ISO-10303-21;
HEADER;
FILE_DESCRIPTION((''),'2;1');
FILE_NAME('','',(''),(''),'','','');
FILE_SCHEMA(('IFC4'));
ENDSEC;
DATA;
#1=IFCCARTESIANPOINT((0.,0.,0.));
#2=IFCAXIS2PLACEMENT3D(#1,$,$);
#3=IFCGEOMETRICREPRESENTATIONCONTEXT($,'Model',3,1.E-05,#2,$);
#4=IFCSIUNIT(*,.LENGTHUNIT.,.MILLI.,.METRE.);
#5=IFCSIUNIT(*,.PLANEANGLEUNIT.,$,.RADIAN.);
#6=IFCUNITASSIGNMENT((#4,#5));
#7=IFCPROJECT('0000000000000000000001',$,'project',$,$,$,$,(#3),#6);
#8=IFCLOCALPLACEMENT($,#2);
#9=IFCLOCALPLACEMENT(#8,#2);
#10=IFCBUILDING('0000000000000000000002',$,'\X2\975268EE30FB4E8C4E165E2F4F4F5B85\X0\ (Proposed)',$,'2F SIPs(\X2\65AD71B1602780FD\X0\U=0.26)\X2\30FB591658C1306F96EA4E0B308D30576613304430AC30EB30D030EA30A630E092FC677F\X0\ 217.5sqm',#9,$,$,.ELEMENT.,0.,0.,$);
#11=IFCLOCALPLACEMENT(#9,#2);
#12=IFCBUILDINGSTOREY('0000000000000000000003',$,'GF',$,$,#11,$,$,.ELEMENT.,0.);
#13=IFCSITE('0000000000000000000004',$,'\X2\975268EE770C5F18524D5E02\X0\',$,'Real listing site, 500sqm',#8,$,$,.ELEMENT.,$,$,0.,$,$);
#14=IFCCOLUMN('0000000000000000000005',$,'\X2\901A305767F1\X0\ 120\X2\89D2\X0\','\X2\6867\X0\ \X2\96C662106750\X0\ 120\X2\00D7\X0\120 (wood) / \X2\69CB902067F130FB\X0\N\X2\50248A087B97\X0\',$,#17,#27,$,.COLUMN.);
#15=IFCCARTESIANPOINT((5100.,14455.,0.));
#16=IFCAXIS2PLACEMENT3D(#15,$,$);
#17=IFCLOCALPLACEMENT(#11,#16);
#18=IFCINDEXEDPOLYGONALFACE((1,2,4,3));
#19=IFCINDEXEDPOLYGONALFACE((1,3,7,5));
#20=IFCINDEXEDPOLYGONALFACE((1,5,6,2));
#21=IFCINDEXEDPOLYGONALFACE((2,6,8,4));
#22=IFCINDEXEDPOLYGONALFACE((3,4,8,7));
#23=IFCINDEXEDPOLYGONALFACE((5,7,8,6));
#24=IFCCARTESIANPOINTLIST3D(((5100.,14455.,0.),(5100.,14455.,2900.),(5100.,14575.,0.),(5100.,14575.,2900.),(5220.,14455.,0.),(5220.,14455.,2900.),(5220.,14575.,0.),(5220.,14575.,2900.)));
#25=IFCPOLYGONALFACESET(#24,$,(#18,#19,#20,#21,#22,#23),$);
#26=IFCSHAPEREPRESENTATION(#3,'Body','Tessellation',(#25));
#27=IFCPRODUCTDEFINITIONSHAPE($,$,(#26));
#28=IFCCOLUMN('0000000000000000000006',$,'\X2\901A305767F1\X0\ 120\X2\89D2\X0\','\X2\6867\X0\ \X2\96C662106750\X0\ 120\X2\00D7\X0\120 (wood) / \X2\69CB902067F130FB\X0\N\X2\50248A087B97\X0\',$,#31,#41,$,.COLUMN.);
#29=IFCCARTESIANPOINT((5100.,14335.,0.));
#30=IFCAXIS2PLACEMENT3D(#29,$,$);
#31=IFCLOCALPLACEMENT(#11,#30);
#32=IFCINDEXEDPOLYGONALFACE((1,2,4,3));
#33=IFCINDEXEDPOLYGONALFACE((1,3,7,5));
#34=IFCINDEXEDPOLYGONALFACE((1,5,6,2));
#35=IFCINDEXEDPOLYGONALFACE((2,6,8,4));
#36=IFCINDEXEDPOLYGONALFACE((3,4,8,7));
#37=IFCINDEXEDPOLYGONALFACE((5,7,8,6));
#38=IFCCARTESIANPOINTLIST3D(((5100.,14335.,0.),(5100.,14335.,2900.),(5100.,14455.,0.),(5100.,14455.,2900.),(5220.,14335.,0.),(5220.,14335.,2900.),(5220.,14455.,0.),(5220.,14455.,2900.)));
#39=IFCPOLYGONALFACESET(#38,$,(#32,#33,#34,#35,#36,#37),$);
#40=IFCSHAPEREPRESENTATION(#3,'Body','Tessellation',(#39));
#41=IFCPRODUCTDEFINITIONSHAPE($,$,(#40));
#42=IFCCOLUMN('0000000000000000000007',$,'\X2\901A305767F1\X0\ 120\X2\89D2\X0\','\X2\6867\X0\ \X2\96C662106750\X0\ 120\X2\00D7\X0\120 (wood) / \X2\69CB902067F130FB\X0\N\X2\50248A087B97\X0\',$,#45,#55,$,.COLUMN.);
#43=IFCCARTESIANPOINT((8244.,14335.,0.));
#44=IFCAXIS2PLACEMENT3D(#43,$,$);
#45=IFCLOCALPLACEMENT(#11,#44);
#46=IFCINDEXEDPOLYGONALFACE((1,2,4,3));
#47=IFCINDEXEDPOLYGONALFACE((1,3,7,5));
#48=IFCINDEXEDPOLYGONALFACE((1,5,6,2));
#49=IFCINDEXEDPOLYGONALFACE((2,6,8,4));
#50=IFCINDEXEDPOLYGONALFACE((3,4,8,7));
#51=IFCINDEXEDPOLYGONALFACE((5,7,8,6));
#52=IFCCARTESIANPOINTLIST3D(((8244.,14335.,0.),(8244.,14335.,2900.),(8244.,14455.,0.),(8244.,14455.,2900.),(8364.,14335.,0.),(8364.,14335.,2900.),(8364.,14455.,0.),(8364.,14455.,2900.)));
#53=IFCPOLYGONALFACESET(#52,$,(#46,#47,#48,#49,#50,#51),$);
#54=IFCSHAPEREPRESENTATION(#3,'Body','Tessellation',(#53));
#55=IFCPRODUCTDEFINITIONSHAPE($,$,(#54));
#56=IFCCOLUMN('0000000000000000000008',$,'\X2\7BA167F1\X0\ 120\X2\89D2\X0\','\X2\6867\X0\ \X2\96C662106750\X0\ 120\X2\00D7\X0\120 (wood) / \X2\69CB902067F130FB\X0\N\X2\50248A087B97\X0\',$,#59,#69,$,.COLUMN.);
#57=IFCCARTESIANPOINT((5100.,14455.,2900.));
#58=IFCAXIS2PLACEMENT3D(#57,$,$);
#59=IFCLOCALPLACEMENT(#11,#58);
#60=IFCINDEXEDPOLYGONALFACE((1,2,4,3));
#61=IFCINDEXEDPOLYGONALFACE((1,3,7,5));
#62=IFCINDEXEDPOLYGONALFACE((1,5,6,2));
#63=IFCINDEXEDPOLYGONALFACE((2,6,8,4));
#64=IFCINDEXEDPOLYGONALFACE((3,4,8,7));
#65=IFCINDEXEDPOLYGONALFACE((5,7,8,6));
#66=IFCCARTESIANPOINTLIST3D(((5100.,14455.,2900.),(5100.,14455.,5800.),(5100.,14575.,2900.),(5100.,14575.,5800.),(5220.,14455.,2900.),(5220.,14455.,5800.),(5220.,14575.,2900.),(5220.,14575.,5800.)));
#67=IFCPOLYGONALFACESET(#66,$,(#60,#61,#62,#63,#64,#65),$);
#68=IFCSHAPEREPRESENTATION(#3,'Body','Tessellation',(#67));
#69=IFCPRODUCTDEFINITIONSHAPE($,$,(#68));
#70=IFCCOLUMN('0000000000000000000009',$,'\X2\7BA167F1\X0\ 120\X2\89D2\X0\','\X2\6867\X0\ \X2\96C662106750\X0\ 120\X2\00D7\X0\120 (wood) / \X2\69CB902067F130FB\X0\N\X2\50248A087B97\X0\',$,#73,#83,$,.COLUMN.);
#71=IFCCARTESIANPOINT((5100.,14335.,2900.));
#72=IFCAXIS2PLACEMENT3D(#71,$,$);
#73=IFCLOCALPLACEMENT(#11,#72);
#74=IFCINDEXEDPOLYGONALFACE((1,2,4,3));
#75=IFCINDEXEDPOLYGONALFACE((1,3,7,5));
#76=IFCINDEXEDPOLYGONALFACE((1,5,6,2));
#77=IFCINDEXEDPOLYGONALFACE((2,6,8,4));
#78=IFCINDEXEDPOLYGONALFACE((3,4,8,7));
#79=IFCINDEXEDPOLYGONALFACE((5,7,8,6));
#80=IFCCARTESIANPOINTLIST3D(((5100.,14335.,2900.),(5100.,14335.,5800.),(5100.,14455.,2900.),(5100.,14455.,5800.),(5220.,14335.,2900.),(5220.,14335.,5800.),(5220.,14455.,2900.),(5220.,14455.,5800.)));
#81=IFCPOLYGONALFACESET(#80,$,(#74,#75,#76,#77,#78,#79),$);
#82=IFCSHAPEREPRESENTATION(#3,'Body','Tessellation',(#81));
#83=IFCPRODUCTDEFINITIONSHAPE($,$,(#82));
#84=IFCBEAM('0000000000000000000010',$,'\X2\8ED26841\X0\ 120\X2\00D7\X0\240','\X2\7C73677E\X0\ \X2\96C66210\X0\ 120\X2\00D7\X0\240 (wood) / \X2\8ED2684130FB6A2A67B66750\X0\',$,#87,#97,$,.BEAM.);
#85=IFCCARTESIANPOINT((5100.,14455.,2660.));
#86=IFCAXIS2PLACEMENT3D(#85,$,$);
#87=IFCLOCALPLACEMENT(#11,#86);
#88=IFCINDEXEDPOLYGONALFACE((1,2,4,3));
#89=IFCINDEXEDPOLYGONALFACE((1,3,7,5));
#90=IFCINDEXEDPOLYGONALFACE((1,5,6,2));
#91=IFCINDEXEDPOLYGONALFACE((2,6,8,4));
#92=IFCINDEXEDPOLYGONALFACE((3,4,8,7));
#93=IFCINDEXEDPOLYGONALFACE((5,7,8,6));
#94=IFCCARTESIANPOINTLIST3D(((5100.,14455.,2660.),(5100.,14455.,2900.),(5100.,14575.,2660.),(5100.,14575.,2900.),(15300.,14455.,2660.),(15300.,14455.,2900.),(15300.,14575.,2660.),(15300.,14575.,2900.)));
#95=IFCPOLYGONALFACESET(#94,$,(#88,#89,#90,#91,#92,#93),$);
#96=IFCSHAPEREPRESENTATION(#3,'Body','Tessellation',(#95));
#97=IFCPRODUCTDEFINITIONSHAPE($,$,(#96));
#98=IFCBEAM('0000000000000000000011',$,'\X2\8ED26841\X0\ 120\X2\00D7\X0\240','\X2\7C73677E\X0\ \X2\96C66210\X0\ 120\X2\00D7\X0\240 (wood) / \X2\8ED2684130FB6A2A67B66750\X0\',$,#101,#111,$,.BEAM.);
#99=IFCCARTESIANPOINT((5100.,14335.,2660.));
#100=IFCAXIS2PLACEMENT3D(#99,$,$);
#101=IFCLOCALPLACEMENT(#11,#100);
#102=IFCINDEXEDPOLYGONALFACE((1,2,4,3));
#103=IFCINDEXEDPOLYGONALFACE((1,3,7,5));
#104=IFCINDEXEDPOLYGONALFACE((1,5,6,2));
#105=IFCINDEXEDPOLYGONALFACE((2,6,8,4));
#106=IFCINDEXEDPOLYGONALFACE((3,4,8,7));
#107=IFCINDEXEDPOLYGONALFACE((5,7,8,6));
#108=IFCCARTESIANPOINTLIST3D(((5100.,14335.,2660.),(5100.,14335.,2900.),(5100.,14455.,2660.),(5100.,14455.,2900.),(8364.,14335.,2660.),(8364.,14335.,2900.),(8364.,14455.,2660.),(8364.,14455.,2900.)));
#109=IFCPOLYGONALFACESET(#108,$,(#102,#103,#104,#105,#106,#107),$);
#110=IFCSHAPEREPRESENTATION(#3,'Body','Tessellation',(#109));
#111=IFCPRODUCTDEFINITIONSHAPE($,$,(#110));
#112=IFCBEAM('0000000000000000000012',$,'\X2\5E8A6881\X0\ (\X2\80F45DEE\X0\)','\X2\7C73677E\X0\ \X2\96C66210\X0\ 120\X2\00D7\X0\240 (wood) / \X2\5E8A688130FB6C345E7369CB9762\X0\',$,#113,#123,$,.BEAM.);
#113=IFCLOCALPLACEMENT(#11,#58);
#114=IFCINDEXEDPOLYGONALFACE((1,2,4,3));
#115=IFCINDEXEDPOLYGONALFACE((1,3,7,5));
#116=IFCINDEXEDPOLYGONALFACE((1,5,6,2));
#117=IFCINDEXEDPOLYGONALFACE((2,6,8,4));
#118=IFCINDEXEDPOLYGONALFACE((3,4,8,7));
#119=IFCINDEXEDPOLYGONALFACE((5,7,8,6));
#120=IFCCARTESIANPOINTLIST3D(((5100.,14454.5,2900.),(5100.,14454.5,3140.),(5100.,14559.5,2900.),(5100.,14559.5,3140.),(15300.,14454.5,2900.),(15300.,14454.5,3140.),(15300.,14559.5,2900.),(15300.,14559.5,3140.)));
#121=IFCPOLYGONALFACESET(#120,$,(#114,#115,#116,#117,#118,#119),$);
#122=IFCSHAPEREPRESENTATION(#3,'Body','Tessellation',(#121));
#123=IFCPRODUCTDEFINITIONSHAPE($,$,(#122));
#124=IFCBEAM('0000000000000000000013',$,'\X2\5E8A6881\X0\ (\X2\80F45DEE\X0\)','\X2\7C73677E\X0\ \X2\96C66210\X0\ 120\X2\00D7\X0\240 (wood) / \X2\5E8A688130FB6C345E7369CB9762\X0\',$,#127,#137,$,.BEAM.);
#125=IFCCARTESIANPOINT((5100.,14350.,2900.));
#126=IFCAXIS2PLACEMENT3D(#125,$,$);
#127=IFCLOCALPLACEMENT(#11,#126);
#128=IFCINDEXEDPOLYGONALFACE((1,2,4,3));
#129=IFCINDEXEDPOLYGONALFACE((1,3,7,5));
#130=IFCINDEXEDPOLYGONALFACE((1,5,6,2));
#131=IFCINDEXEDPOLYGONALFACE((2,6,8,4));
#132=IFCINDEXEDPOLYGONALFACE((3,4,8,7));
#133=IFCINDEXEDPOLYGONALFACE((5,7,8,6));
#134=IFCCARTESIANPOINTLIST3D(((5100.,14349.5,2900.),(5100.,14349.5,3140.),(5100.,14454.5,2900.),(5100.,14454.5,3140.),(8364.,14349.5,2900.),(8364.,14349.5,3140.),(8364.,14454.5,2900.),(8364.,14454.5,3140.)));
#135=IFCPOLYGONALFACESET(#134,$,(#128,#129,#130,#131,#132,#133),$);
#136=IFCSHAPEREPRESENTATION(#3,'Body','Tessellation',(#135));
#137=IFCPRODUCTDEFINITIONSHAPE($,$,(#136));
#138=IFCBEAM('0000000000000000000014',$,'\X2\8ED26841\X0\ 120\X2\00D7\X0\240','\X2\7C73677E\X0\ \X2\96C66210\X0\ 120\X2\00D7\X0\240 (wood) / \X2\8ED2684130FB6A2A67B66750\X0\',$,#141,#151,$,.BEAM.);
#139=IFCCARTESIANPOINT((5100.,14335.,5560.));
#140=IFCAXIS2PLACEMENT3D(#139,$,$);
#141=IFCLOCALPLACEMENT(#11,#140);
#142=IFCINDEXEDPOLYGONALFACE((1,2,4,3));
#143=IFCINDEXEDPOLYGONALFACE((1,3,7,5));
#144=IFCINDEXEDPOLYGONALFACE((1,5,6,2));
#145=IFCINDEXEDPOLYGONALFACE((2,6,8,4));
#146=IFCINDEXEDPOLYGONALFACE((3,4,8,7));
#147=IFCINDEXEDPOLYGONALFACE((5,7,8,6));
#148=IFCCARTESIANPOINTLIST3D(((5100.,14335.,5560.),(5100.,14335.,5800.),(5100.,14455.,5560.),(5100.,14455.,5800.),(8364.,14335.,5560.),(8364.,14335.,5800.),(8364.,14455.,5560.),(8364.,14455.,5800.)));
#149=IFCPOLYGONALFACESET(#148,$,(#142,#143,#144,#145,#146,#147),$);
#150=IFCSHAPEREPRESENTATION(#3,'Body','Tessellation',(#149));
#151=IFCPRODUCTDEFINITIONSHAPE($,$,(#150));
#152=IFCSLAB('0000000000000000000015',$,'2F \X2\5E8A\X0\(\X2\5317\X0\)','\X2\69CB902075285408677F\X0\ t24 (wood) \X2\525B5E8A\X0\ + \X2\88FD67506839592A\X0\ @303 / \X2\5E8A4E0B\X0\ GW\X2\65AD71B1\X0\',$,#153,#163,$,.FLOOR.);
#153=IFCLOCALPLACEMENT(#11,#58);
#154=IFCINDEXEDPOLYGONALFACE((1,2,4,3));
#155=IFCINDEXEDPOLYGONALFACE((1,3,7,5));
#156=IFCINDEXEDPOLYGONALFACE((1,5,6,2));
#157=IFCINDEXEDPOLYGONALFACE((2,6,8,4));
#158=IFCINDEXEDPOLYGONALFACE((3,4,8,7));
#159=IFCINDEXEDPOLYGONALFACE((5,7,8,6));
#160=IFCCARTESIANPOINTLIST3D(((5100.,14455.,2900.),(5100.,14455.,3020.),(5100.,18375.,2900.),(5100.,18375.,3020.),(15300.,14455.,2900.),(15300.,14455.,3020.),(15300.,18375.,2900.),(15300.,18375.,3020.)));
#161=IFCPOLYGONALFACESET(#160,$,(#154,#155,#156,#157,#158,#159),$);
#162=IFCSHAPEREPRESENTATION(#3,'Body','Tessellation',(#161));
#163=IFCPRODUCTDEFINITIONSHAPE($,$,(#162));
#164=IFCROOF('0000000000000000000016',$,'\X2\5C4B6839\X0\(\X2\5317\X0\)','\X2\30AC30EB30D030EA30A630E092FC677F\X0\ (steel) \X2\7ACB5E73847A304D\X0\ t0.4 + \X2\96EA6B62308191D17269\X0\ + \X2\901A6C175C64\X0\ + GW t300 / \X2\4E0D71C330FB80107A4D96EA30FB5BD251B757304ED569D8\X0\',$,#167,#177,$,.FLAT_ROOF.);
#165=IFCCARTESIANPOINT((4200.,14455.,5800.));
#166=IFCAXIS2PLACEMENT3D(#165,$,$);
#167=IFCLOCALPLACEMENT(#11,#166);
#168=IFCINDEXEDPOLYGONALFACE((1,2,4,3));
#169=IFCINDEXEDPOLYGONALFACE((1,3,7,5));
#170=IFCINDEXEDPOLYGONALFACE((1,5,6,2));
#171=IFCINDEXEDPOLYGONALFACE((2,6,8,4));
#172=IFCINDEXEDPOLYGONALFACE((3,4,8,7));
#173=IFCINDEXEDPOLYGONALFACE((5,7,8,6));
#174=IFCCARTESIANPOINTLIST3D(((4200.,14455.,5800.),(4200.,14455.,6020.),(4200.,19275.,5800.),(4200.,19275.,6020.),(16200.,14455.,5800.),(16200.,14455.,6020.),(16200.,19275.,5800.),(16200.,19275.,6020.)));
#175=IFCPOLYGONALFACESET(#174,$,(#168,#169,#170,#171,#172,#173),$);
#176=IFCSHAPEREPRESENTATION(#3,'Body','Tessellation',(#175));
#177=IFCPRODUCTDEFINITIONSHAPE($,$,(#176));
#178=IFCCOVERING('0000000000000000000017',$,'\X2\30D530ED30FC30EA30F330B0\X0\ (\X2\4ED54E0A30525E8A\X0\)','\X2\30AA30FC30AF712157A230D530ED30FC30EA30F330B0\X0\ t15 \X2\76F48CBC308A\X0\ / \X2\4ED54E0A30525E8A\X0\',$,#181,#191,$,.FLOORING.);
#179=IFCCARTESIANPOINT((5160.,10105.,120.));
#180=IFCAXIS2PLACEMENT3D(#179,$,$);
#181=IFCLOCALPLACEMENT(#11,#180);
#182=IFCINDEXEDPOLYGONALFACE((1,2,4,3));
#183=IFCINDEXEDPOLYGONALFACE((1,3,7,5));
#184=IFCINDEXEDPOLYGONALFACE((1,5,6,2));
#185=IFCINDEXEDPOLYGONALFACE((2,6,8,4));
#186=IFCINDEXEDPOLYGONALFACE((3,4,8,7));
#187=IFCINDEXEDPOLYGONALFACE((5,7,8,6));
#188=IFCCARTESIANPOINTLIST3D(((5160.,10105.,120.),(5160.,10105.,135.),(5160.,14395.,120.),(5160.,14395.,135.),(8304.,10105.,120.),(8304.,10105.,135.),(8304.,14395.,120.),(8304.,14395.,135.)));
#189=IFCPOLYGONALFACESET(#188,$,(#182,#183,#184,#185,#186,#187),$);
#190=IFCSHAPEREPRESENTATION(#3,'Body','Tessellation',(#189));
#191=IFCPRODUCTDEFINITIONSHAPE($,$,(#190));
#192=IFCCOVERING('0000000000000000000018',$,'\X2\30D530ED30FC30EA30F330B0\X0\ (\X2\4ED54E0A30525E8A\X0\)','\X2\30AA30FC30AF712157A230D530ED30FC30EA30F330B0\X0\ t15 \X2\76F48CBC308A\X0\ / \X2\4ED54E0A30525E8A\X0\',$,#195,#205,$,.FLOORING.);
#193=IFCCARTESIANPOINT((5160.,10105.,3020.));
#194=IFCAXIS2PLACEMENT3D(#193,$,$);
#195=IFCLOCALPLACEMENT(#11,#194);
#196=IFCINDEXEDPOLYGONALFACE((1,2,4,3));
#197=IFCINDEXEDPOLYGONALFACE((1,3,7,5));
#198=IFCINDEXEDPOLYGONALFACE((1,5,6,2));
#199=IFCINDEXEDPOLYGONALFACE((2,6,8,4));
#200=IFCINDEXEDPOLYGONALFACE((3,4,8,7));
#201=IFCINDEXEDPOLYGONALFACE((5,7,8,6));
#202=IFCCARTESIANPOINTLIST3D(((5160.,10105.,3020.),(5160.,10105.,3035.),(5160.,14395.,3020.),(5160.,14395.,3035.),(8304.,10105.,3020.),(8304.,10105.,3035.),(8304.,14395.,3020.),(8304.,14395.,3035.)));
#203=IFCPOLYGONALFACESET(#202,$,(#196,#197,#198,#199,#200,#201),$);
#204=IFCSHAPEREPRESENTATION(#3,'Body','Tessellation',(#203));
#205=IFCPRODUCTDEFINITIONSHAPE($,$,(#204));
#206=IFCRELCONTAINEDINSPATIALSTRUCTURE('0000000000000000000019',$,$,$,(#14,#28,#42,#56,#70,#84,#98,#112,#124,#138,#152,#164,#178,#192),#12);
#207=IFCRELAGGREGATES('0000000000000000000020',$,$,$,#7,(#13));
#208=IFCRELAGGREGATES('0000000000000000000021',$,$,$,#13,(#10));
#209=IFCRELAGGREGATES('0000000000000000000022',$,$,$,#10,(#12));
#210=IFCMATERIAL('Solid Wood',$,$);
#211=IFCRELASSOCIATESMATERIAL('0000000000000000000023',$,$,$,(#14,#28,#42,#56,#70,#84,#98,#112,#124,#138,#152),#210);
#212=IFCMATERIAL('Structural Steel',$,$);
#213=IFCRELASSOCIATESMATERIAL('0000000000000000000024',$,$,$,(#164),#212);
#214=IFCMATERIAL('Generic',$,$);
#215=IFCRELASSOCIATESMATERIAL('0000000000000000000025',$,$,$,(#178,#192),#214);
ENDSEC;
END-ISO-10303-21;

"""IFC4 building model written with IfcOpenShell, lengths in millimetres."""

from ifc_helpers import new_model, si_unit, frame, frame_2d, origin, place, context, project, spatial, rectangle, extrude, material, element, save


model = new_model("IFC4")

# Units and contexts
model_context = context("Model", 3, precision=1e-05, world=origin())
ifc_project = project(units=[si_unit("LENGTHUNIT", "METRE", prefix="MILLI"), si_unit("PLANEANGLEUNIT", "RADIAN")], contexts=[model_context])

# Site, building, storey
site_placement = place(None, origin())
site = spatial("IfcSite", under=ifc_project, at=site_placement, Name="青森県弘前市", ObjectType="Real listing site, 500sqm", CompositionType="ELEMENT", RefElevation=0.0)
building_placement = place(site_placement, origin())
building = spatial("IfcBuilding", under=site, at=building_placement, Name="青森・二世帯住宅 (Proposed)", ObjectType="2F SIPs(断熱性能U=0.26)・外壁は雪下ろし易いガルバリウム鋼板 217.5sqm", CompositionType="ELEMENT", ElevationOfRefHeight=0.0, ElevationOfTerrain=0.0)
storey_placement = place(building_placement, origin())
storey = spatial("IfcBuildingStorey", under=building, at=storey_placement, Name="GF", CompositionType="ELEMENT", Elevation=0.0)

# Columns
ifc_material_1 = material(Name="Solid Wood")
column_1_placement = place(storey_placement, frame((5100.0, 14455.0, 0.0)))
element("IfcColumn", 1, at=column_1_placement, inside=storey, material=ifc_material_1, Name="通し柱 120角", Description="桧 集成材 120×120 (wood) / 構造柱・N値計算", PredefinedType="COLUMN", context=model_context, shape_type="SweptSolid", body=[
    extrude(rectangle(XDim=120.0, YDim=120.0, at=frame_2d((60.0, 60.0))), frame((5100.0, 14455.0, 0.0)), (0.0, 0.0, 1.0), 2900.0),
])
column_2_placement = place(storey_placement, frame((5100.0, 14335.0, 0.0)))
element("IfcColumn", 2, at=column_2_placement, inside=storey, material=ifc_material_1, Name="通し柱 120角", Description="桧 集成材 120×120 (wood) / 構造柱・N値計算", PredefinedType="COLUMN", context=model_context, shape_type="SweptSolid", body=[
    extrude(rectangle(XDim=120.0, YDim=120.0, at=frame_2d((60.0, 60.0))), frame((5100.0, 14335.0, 0.0)), (0.0, 0.0, 1.0), 2900.0),
])
column_3_placement = place(storey_placement, frame((8244.0, 14335.0, 0.0)))
element("IfcColumn", 3, at=column_3_placement, inside=storey, material=ifc_material_1, Name="通し柱 120角", Description="桧 集成材 120×120 (wood) / 構造柱・N値計算", PredefinedType="COLUMN", context=model_context, shape_type="SweptSolid", body=[
    extrude(rectangle(XDim=120.0, YDim=120.0, at=frame_2d((60.0, 60.0))), frame((8244.0, 14335.0, 0.0)), (0.0, 0.0, 1.0), 2900.0),
])
column_4_placement = place(storey_placement, frame((5100.0, 14455.0, 2900.0)))
element("IfcColumn", 4, at=column_4_placement, inside=storey, material=ifc_material_1, Name="管柱 120角", Description="桧 集成材 120×120 (wood) / 構造柱・N値計算", PredefinedType="COLUMN", context=model_context, shape_type="SweptSolid", body=[
    extrude(rectangle(XDim=120.0, YDim=120.0, at=frame_2d((60.0, 60.0))), frame((5100.0, 14455.0, 2900.0)), (0.0, 0.0, 1.0), 2900.0),
])
column_5_placement = place(storey_placement, frame((5100.0, 14335.0, 2900.0)))
element("IfcColumn", 5, at=column_5_placement, inside=storey, material=ifc_material_1, Name="管柱 120角", Description="桧 集成材 120×120 (wood) / 構造柱・N値計算", PredefinedType="COLUMN", context=model_context, shape_type="SweptSolid", body=[
    extrude(rectangle(XDim=120.0, YDim=120.0, at=frame_2d((60.0, 60.0))), frame((5100.0, 14335.0, 2900.0)), (0.0, 0.0, 1.0), 2900.0),
])

# Beams
beam_1_placement = place(storey_placement, frame((5100.0, 14455.0, 2660.0)))
element("IfcBeam", 6, at=beam_1_placement, inside=storey, material=ifc_material_1, Name="軒桁 120×240", Description="米松 集成 120×240 (wood) / 軒桁・横架材", PredefinedType="BEAM", context=model_context, shape_type="SweptSolid", body=[
    extrude(rectangle(XDim=10200.0, YDim=120.0, at=frame_2d((5100.0, 60.0))), frame((5100.0, 14455.0, 2660.0)), (0.0, 0.0, 1.0), 240.0),
])
beam_2_placement = place(storey_placement, frame((5100.0, 14335.0, 2660.0)))
element("IfcBeam", 7, at=beam_2_placement, inside=storey, material=ifc_material_1, Name="軒桁 120×240", Description="米松 集成 120×240 (wood) / 軒桁・横架材", PredefinedType="BEAM", context=model_context, shape_type="SweptSolid", body=[
    extrude(rectangle(XDim=3264.0, YDim=120.0, at=frame_2d((1632.0, 60.0))), frame((5100.0, 14335.0, 2660.0)), (0.0, 0.0, 1.0), 240.0),
])
beam_3_placement = place(storey_placement, frame((5100.0, 14455.0, 2900.0)))
element("IfcBeam", 8, at=beam_3_placement, inside=storey, material=ifc_material_1, Name="床梁 (胴差)", Description="米松 集成 120×240 (wood) / 床梁・水平構面", PredefinedType="BEAM", context=model_context, shape_type="SweptSolid", body=[
    extrude(rectangle(XDim=10200.0, YDim=105.0, at=frame_2d((5100.0, 52.0))), frame((5100.0, 14455.0, 2900.0)), (0.0, 0.0, 1.0), 240.0),
])
beam_4_placement = place(storey_placement, frame((5100.0, 14350.0, 2900.0)))
element("IfcBeam", 9, at=beam_4_placement, inside=storey, material=ifc_material_1, Name="床梁 (胴差)", Description="米松 集成 120×240 (wood) / 床梁・水平構面", PredefinedType="BEAM", context=model_context, shape_type="SweptSolid", body=[
    extrude(rectangle(XDim=3264.0, YDim=105.0, at=frame_2d((1632.0, 52.0))), frame((5100.0, 14350.0, 2900.0)), (0.0, 0.0, 1.0), 240.0),
])
beam_5_placement = place(storey_placement, frame((5100.0, 14335.0, 5560.0)))
element("IfcBeam", 10, at=beam_5_placement, inside=storey, material=ifc_material_1, Name="軒桁 120×240", Description="米松 集成 120×240 (wood) / 軒桁・横架材", PredefinedType="BEAM", context=model_context, shape_type="SweptSolid", body=[
    extrude(rectangle(XDim=3264.0, YDim=120.0, at=frame_2d((1632.0, 60.0))), frame((5100.0, 14335.0, 5560.0)), (0.0, 0.0, 1.0), 240.0),
])

# Slab
slab_1_placement = place(storey_placement, frame((5100.0, 14455.0, 2900.0)))
element("IfcSlab", 11, at=slab_1_placement, inside=storey, material=ifc_material_1, Name="2F 床(北)", Description="構造用合板 t24 (wood) 剛床 + 製材根太 @303 / 床下 GW断熱", PredefinedType="FLOOR", context=model_context, shape_type="SweptSolid", body=[
    extrude(rectangle(XDim=10200.0, YDim=3920.0, at=frame_2d((5100.0, 1960.0))), frame((5100.0, 14455.0, 2900.0)), (0.0, 0.0, 1.0), 120.0),
])

# Roof
ifc_material_2 = material(Name="Structural Steel")
for number, where, name in (
    (12, (4200.0, 14455.0, 5800.0), "屋根(北)"),
):
    element("IfcRoof", number, at=place(storey_placement, frame(where)), inside=storey, material=ifc_material_2, Name=name, Description="ガルバリウム鋼板 (steel) 立平葺き t0.4 + 雪止め金物 + 通気層 + GW t300 / 不燃・耐積雪・寒冷地仕様", PredefinedType="FLAT_ROOF", context=model_context, shape_type="SweptSolid", body=[
        extrude(rectangle(XDim=12000.0, YDim=4820.0, at=frame_2d((6000.0, 2410.0))), frame((4200.0, 14455.0, 5800.0)), (0.0, 0.0, 1.0), 220.0),
    ])

# Coverings
ifc_material_3 = material(Name="Generic")
covering_1_placement = place(storey_placement, frame((5160.0, 10105.0, 120.0)))
element("IfcCovering", 13, at=covering_1_placement, inside=storey, material=ifc_material_3, Name="フローリング (仕上げ床)", Description="オーク無垢フローリング t15 直貼り / 仕上げ床", PredefinedType="FLOORING", context=model_context, shape_type="SweptSolid", body=[
    extrude(rectangle(XDim=3144.0, YDim=4290.0, at=frame_2d((1572.0, 2145.0))), frame((5160.0, 10105.0, 120.0)), (0.0, 0.0, 1.0), 15.0),
])
covering_2_placement = place(storey_placement, frame((5160.0, 10105.0, 3020.0)))
element("IfcCovering", 14, at=covering_2_placement, inside=storey, material=ifc_material_3, Name="フローリング (仕上げ床)", Description="オーク無垢フローリング t15 直貼り / 仕上げ床", PredefinedType="FLOORING", context=model_context, shape_type="SweptSolid", body=[
    extrude(rectangle(XDim=3144.0, YDim=4290.0, at=frame_2d((1572.0, 2145.0))), frame((5160.0, 10105.0, 3020.0)), (0.0, 0.0, 1.0), 15.0),
])

save(model, "model.ifc")
